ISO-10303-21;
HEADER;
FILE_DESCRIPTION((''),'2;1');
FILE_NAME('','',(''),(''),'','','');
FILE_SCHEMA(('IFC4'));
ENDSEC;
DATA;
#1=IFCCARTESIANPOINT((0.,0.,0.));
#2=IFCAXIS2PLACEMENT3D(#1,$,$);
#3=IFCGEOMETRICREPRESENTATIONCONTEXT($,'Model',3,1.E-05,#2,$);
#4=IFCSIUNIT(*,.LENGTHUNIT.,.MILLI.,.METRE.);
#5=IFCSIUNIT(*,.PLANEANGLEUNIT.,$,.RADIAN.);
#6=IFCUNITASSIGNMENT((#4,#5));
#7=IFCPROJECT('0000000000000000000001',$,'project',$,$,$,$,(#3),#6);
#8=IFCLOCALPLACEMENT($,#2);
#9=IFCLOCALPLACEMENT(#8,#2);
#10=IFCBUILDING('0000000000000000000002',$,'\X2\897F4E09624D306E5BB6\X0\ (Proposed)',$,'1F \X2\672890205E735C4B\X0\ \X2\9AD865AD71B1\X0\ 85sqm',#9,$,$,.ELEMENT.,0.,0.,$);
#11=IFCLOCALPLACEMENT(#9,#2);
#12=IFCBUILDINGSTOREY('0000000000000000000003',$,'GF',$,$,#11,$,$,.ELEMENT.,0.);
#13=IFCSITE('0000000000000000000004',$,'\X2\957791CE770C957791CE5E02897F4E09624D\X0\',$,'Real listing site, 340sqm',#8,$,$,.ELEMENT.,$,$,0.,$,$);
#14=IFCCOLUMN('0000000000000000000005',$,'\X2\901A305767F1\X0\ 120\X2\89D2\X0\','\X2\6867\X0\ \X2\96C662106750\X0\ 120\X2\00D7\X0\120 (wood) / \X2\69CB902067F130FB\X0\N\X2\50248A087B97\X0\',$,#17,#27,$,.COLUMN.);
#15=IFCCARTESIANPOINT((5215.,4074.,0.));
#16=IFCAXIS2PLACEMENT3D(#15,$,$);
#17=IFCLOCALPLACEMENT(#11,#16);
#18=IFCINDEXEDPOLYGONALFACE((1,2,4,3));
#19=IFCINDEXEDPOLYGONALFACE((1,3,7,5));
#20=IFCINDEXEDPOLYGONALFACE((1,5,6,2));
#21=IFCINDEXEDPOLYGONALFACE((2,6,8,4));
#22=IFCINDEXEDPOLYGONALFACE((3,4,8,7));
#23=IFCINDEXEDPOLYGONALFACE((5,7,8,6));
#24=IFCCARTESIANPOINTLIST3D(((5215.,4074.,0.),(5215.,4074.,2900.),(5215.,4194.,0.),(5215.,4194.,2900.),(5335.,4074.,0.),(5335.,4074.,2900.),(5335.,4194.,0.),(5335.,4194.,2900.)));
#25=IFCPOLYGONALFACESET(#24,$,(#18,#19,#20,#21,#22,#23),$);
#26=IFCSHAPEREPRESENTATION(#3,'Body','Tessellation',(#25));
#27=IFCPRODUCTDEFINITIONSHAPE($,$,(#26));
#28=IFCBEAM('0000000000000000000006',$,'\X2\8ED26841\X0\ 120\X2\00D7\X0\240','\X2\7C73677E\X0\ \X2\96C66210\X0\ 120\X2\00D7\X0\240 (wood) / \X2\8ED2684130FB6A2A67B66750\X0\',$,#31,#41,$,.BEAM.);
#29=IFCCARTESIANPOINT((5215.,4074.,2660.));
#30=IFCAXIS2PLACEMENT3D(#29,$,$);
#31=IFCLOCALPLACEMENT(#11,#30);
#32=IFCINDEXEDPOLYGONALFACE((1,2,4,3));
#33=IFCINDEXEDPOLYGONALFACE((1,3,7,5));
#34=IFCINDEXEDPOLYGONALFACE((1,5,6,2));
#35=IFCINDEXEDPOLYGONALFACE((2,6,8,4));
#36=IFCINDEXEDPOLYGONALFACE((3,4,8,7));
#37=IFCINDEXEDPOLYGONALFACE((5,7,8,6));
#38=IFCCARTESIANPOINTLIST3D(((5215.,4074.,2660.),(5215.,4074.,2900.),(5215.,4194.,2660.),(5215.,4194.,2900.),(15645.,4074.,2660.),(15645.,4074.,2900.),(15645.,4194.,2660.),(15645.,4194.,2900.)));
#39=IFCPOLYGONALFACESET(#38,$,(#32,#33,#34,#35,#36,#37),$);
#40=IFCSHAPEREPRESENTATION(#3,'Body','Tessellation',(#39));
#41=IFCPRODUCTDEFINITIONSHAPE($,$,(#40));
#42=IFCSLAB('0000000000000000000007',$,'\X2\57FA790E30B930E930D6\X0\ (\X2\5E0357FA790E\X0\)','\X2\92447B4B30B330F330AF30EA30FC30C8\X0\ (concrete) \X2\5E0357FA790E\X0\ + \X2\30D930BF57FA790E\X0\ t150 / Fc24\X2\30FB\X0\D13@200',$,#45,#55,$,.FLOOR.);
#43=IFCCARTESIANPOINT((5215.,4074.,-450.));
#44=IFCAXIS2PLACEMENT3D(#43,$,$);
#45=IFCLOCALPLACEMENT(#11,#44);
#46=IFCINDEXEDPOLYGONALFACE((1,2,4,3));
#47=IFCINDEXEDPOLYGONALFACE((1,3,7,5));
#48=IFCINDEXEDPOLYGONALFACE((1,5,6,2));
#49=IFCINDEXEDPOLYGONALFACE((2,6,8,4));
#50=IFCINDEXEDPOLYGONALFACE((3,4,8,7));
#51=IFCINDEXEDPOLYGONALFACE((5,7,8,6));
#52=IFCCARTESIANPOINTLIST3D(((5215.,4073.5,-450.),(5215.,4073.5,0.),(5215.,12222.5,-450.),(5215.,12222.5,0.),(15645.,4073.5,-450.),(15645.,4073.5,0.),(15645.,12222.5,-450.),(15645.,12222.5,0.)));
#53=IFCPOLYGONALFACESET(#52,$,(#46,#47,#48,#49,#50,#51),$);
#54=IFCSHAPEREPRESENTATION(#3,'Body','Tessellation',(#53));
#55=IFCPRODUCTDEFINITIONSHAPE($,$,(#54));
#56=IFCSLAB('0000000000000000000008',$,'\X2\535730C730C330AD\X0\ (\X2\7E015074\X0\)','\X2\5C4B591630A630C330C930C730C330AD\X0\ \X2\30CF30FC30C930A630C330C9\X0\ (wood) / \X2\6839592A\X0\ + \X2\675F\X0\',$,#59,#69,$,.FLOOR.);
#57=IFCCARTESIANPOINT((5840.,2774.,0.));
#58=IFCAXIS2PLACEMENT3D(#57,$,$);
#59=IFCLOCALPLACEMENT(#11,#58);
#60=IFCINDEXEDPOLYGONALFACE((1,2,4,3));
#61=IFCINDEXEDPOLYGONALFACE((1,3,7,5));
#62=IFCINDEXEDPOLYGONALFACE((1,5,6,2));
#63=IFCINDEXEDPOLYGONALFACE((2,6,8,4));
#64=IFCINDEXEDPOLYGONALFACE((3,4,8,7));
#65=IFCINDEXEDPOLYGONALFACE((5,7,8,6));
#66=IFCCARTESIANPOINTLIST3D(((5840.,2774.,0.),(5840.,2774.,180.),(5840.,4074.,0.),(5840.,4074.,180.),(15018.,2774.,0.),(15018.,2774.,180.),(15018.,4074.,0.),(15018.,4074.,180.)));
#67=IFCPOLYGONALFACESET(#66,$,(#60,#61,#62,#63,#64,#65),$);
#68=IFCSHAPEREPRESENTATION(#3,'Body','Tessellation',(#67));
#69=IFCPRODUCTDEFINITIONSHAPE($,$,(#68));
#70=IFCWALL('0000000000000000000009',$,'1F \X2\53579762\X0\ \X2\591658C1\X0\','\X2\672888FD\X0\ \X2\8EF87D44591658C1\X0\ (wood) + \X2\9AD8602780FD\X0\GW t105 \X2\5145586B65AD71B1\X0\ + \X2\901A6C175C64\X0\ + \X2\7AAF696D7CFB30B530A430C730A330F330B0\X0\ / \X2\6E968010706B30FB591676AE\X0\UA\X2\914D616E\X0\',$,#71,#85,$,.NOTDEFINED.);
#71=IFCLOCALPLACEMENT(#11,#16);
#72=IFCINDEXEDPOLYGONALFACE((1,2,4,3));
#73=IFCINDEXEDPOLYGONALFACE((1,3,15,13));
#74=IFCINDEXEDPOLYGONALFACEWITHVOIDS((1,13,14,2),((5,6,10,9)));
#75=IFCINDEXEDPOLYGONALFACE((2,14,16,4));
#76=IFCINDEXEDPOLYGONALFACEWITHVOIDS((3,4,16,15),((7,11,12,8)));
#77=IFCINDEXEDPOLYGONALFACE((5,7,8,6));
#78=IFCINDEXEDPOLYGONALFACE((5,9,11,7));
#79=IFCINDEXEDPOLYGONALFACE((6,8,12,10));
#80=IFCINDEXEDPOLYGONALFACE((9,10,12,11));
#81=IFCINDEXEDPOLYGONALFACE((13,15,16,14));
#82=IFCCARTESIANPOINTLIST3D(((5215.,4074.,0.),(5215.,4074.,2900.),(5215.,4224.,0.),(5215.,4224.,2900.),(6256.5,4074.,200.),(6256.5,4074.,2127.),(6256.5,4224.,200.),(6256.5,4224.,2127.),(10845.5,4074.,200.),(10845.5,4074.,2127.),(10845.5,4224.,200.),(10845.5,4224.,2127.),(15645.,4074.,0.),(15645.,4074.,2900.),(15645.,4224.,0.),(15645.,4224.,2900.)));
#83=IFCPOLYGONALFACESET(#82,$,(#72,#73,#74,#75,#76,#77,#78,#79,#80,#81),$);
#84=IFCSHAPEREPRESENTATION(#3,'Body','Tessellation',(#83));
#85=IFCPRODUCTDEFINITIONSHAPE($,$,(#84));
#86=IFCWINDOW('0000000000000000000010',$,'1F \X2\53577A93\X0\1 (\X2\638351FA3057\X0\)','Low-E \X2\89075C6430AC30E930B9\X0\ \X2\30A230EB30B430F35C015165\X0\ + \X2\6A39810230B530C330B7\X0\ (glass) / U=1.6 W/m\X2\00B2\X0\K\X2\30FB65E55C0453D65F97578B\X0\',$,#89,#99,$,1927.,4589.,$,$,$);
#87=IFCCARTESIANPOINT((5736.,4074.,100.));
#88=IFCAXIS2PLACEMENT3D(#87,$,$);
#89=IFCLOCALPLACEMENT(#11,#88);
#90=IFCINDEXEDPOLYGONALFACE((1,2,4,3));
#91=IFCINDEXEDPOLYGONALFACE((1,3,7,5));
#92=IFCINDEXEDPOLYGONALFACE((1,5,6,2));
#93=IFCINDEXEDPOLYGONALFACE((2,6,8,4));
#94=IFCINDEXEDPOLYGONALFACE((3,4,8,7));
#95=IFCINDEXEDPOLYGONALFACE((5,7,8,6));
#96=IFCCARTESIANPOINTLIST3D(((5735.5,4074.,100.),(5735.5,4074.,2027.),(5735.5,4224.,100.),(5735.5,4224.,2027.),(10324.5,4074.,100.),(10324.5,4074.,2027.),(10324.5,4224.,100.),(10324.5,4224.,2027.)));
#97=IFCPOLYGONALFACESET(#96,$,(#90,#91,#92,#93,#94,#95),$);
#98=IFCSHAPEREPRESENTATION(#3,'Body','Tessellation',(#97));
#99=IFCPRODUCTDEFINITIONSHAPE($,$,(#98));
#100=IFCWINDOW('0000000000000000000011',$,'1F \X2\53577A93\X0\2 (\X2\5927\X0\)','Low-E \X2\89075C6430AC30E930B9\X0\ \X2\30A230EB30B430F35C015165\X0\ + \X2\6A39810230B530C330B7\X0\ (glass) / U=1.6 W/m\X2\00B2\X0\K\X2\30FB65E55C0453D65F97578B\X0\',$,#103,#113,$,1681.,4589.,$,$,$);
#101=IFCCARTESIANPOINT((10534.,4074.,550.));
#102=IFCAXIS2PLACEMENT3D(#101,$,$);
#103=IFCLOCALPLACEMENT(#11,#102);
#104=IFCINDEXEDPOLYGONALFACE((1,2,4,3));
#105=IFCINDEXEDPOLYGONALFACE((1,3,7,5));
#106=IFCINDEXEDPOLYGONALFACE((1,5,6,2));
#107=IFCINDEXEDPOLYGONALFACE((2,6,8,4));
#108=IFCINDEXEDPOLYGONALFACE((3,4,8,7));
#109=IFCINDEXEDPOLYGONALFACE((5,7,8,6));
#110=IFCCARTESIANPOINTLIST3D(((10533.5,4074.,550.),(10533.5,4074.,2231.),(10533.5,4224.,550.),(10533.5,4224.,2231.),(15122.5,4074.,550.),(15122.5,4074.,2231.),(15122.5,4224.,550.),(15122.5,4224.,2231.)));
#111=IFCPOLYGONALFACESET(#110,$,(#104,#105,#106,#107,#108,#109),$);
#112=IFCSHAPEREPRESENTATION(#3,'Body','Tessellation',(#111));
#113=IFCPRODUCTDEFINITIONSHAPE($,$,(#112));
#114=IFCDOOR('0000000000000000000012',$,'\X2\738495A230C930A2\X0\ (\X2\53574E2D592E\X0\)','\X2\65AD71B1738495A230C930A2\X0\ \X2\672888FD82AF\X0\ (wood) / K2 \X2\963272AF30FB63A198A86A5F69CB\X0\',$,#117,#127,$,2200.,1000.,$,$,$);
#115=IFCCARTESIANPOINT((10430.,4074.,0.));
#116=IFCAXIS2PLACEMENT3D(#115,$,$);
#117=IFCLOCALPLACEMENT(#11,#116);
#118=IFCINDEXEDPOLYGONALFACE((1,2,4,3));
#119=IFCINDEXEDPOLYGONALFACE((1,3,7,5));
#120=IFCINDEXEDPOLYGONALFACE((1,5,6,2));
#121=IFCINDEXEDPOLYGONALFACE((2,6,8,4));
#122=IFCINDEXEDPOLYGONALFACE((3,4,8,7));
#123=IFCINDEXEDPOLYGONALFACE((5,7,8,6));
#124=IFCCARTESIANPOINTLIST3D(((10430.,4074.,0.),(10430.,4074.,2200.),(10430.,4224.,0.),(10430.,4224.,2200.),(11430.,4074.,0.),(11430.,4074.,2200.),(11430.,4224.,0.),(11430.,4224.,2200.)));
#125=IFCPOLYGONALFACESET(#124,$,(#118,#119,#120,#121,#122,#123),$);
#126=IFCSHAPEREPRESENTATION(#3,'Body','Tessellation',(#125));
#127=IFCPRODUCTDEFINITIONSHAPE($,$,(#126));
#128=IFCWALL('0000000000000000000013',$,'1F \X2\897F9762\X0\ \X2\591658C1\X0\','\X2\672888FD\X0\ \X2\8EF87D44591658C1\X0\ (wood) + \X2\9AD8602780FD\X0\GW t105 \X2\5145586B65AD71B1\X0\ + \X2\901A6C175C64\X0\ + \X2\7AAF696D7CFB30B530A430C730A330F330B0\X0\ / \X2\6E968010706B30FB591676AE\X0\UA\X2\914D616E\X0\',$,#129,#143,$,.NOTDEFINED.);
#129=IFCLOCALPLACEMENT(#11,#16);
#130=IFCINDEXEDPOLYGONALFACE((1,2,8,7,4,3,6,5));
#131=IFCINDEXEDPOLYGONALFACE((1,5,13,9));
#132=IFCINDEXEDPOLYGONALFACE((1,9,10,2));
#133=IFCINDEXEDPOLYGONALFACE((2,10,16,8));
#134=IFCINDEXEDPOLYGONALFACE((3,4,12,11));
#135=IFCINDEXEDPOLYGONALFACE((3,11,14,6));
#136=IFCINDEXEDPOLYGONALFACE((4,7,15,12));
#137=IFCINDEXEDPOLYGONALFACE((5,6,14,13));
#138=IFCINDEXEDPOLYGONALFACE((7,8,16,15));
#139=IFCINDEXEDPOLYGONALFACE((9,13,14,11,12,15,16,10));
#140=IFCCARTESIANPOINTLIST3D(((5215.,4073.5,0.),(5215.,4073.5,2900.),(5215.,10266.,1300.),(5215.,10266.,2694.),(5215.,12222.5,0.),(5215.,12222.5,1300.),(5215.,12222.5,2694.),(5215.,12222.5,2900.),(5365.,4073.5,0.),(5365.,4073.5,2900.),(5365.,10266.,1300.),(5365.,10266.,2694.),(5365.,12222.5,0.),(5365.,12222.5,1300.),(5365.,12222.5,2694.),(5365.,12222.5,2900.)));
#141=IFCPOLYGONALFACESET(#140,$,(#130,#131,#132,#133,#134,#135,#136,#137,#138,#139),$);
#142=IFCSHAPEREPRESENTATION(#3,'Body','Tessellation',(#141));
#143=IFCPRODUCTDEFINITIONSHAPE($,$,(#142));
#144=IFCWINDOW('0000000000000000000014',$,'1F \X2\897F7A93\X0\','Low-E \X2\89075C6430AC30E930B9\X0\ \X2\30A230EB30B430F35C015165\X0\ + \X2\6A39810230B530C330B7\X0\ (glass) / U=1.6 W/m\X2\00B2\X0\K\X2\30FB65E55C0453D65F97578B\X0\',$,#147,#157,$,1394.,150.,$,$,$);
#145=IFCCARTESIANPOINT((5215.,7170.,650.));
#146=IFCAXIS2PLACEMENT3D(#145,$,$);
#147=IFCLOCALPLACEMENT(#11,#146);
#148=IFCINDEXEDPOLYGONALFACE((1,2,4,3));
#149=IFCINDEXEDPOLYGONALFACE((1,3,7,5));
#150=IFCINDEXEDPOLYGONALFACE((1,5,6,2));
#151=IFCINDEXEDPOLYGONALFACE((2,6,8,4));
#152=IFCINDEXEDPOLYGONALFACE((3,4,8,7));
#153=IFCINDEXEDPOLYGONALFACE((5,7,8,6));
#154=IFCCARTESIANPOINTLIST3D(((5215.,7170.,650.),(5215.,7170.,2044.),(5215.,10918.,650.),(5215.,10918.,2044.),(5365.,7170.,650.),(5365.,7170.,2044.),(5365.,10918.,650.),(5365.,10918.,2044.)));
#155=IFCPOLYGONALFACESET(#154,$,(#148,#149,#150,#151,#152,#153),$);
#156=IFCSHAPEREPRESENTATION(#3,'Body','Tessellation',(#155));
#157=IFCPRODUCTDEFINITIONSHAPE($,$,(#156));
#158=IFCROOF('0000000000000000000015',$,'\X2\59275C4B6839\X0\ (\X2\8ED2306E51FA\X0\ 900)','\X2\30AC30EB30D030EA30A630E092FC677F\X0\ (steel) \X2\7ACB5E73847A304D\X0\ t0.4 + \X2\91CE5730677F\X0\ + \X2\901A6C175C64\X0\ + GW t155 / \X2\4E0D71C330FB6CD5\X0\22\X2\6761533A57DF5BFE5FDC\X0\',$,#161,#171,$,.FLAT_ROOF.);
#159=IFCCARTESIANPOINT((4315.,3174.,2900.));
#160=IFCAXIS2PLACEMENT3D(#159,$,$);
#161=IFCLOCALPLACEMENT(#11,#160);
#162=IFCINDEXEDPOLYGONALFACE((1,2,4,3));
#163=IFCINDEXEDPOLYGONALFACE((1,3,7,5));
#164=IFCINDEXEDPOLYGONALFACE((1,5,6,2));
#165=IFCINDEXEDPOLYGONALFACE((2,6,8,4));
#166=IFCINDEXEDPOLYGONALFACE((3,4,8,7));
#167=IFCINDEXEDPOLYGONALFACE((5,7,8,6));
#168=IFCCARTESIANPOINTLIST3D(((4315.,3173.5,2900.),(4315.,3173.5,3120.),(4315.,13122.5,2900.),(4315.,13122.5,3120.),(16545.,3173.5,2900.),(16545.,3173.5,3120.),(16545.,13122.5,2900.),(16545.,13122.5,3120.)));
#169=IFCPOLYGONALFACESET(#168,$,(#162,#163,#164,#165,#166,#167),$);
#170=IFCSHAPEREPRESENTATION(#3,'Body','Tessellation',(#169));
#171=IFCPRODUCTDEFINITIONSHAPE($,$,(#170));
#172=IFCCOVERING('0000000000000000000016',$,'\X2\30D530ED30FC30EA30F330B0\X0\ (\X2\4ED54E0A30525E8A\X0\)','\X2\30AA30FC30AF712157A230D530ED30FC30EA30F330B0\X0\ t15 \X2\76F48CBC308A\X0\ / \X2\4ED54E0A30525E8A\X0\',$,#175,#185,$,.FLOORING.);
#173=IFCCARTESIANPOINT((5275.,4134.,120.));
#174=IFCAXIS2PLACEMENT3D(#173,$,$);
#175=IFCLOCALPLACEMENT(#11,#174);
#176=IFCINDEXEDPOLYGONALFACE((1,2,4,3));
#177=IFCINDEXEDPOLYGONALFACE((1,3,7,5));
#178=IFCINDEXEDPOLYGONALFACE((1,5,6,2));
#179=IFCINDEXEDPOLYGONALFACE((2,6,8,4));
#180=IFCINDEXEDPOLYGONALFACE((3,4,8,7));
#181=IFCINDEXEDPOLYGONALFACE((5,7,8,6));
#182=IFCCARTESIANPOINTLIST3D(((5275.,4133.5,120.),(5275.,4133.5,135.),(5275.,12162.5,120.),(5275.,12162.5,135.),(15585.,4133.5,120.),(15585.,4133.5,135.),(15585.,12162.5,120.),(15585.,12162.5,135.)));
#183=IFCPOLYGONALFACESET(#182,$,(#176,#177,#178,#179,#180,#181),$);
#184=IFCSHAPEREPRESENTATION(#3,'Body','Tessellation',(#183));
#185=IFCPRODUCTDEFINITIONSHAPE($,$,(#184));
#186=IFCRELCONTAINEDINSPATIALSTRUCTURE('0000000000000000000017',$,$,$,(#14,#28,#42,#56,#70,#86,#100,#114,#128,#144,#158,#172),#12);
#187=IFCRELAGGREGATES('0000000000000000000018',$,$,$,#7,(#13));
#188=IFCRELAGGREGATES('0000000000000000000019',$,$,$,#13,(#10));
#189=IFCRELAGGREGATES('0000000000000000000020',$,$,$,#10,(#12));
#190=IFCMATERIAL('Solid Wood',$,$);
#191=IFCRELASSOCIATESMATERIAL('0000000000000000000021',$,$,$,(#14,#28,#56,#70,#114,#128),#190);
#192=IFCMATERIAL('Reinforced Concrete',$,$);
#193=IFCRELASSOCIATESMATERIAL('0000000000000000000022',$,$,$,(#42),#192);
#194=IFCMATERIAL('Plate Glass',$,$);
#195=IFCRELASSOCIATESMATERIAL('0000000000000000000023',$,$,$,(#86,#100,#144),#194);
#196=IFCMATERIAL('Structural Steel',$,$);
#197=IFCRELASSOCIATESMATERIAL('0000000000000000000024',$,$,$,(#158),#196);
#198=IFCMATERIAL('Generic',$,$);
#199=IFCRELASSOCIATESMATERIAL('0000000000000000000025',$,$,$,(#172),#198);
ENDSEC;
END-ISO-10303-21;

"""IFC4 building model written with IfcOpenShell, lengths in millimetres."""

from ifc_helpers import new_model, si_unit, frame, frame_2d, origin, place, context, project, spatial, rectangle, extrude, material, element, fill, save


model = new_model("IFC4")

# Units and contexts
model_context = context("Model", 3, precision=1e-05, world=origin())
ifc_project = project(units=[si_unit("LENGTHUNIT", "METRE", prefix="MILLI"), si_unit("PLANEANGLEUNIT", "RADIAN")], contexts=[model_context])

# Site, building, storey
site_placement = place(None, origin())
site = spatial("IfcSite", under=ifc_project, at=site_placement, Name="長野県長野市西三才", ObjectType="Real listing site, 340sqm", CompositionType="ELEMENT", RefElevation=0.0)
building_placement = place(site_placement, origin())
building = spatial("IfcBuilding", under=site, at=building_placement, Name="西三才の家 (Proposed)", ObjectType="1F 木造平屋 高断熱 85sqm", CompositionType="ELEMENT", ElevationOfRefHeight=0.0, ElevationOfTerrain=0.0)
storey_placement = place(building_placement, origin())
storey = spatial("IfcBuildingStorey", under=building, at=storey_placement, Name="GF", CompositionType="ELEMENT", Elevation=0.0)

# Column
ifc_material_1 = material(Name="Solid Wood")
column_1_placement = place(storey_placement, frame((5215.0, 4074.0, 0.0)))
element("IfcColumn", 1, at=column_1_placement, inside=storey, material=ifc_material_1, Name="通し柱 120角", Description="桧 集成材 120×120 (wood) / 構造柱・N値計算", PredefinedType="COLUMN", context=model_context, shape_type="SweptSolid", body=[
    extrude(rectangle(XDim=120.0, YDim=120.0, at=frame_2d((60.0, 60.0))), frame((5215.0, 4074.0, 0.0)), (0.0, 0.0, 1.0), 2900.0),
])

# Beam
beam_1_placement = place(storey_placement, frame((5215.0, 4074.0, 2660.0)))
element("IfcBeam", 2, at=beam_1_placement, inside=storey, material=ifc_material_1, Name="軒桁 120×240", Description="米松 集成 120×240 (wood) / 軒桁・横架材", PredefinedType="BEAM", context=model_context, shape_type="SweptSolid", body=[
    extrude(rectangle(XDim=10430.0, YDim=120.0, at=frame_2d((5215.0, 60.0))), frame((5215.0, 4074.0, 2660.0)), (0.0, 0.0, 1.0), 240.0),
])

# Slabs
ifc_material_2 = material(Name="Reinforced Concrete")
slab_1_placement = place(storey_placement, frame((5215.0, 4074.0, -450.0)))
element("IfcSlab", 3, at=slab_1_placement, inside=storey, material=ifc_material_2, Name="基礎スラブ (布基礎)", Description="鉄筋コンクリート (concrete) 布基礎 + ベタ基礎 t150 / Fc24・D13@200", PredefinedType="FLOOR", context=model_context, shape_type="SweptSolid", body=[
    extrude(rectangle(XDim=10430.0, YDim=8149.0, at=frame_2d((5215.0, 4074.0))), frame((5215.0, 4074.0, -450.0)), (0.0, 0.0, 1.0), 450.0),
])
slab_2_placement = place(storey_placement, frame((5840.0, 2774.0, 0.0)))
element("IfcSlab", 4, at=slab_2_placement, inside=storey, material=ifc_material_1, Name="南デッキ (縁側)", Description="屋外ウッドデッキ ハードウッド (wood) / 根太 + 束", PredefinedType="FLOOR", context=model_context, shape_type="SweptSolid", body=[
    extrude(rectangle(XDim=9178.0, YDim=1300.0, at=frame_2d((4589.0, 650.0))), frame((5840.0, 2774.0, 0.0)), (0.0, 0.0, 1.0), 180.0),
])

# Wall, openings, windows, door
wall_1_placement = place(storey_placement, frame((5215.0, 4074.0, 0.0)))
wall_1 = element("IfcWall", 5, at=wall_1_placement, inside=storey, material=ifc_material_1, Name="1F 南面 外壁", Description="木製 軸組外壁 (wood) + 高性能GW t105 充填断熱 + 通気層 + 窯業系サイディング / 準耐火・外皮UA配慮", PredefinedType="NOTDEFINED", context=model_context, shape_type="SweptSolid", body=[
    extrude(rectangle(XDim=10430.0, YDim=150.0, at=frame_2d((5215.0, 75.0))), frame((5215.0, 4074.0, 0.0)), (0.0, 0.0, 1.0), 2900.0),
])
opening_1_placement = place(storey_placement, frame((5736.0, 4074.0, 100.0)))
opening_1 = element("IfcOpeningElement", 6, at=opening_1_placement, cuts=wall_1, PredefinedType="NOTDEFINED", context=model_context, shape_type="SweptSolid", body=[
    extrude(rectangle(XDim=4589.0, YDim=150.0, at=frame_2d((2294.0, 75.0))), frame((5736.0, 4074.0, 100.0)), (0.0, 0.0, 1.0), 1927.0),
])
opening_2_placement = place(storey_placement, frame((10534.0, 4074.0, 550.0)))
opening_2 = element("IfcOpeningElement", 7, at=opening_2_placement, cuts=wall_1, PredefinedType="NOTDEFINED", context=model_context, shape_type="SweptSolid", body=[
    extrude(rectangle(XDim=4589.0, YDim=150.0, at=frame_2d((2294.0, 75.0))), frame((10534.0, 4074.0, 550.0)), (0.0, 0.0, 1.0), 1681.0),
])
opening_3_placement = place(storey_placement, frame((10430.0, 4074.0, 0.0)))
opening_3 = element("IfcOpeningElement", 8, at=opening_3_placement, cuts=wall_1, PredefinedType="NOTDEFINED", context=model_context, shape_type="SweptSolid", body=[
    extrude(rectangle(XDim=1000.0, YDim=150.0, at=frame_2d((500.0, 75.0))), frame((10430.0, 4074.0, 0.0)), (0.0, 0.0, 1.0), 2200.0),
])
ifc_material_3 = material(Name="Plate Glass")
window_1_placement = place(storey_placement, frame((5736.0, 4074.0, 100.0)))
window_1 = element("IfcWindow", 9, at=window_1_placement, inside=storey, material=ifc_material_3, Name="1F 南窓1 (掃出し)", Description="Low-E 複層ガラス アルゴン封入 + 樹脂サッシ (glass) / U=1.6 W/m²K・日射取得型", OverallHeight=1927.0, OverallWidth=4589.0, context=model_context, shape_type="SweptSolid", body=[
    extrude(rectangle(XDim=4589.0, YDim=150.0, at=frame_2d((2294.0, 75.0))), frame((5736.0, 4074.0, 100.0)), (0.0, 0.0, 1.0), 1927.0),
])
fill(opening_1, window_1)
window_2_placement = place(storey_placement, frame((10534.0, 4074.0, 550.0)))
window_2 = element("IfcWindow", 10, at=window_2_placement, inside=storey, material=ifc_material_3, Name="1F 南窓2 (大)", Description="Low-E 複層ガラス アルゴン封入 + 樹脂サッシ (glass) / U=1.6 W/m²K・日射取得型", OverallHeight=1681.0, OverallWidth=4589.0, context=model_context, shape_type="SweptSolid", body=[
    extrude(rectangle(XDim=4589.0, YDim=150.0, at=frame_2d((2294.0, 75.0))), frame((10534.0, 4074.0, 550.0)), (0.0, 0.0, 1.0), 1681.0),
])
fill(opening_2, window_2)
door_placement = place(storey_placement, frame((10430.0, 4074.0, 0.0)))
door = element("IfcDoor", 11, at=door_placement, inside=storey, material=ifc_material_1, Name="玄関ドア (南中央)", Description="断熱玄関ドア 木製芯 (wood) / K2 防犯・採風機構", OverallHeight=2200.0, OverallWidth=1000.0, context=model_context, shape_type="SweptSolid", body=[
    extrude(rectangle(XDim=1000.0, YDim=150.0, at=frame_2d((500.0, 75.0))), frame((10430.0, 4074.0, 0.0)), (0.0, 0.0, 1.0), 2200.0),
])
fill(opening_3, door)

# Wall, opening, window
wall_2_placement = place(storey_placement, frame((5215.0, 4074.0, 0.0)))
wall_2 = element("IfcWall", 12, at=wall_2_placement, inside=storey, material=ifc_material_1, Name="1F 西面 外壁", Description="木製 軸組外壁 (wood) + 高性能GW t105 充填断熱 + 通気層 + 窯業系サイディング / 準耐火・外皮UA配慮", PredefinedType="NOTDEFINED", context=model_context, shape_type="SweptSolid", body=[
    extrude(rectangle(XDim=150.0, YDim=8149.0, at=frame_2d((75.0, 4074.0))), frame((5215.0, 4074.0, 0.0)), (0.0, 0.0, 1.0), 2900.0),
])
opening_4_placement = place(storey_placement, frame((5215.0, 7170.0, 650.0)))
opening_4 = element("IfcOpeningElement", 13, at=opening_4_placement, cuts=wall_2, PredefinedType="NOTDEFINED", context=model_context, shape_type="SweptSolid", body=[
    extrude(rectangle(XDim=150.0, YDim=3748.0, at=frame_2d((75.0, 1874.0))), frame((5215.0, 7170.0, 650.0)), (0.0, 0.0, 1.0), 1394.0),
])
window_3_placement = place(storey_placement, frame((5215.0, 7170.0, 650.0)))
window_3 = element("IfcWindow", 14, at=window_3_placement, inside=storey, material=ifc_material_3, Name="1F 西窓", Description="Low-E 複層ガラス アルゴン封入 + 樹脂サッシ (glass) / U=1.6 W/m²K・日射取得型", OverallHeight=1394.0, OverallWidth=150.0, context=model_context, shape_type="SweptSolid", body=[
    extrude(rectangle(XDim=150.0, YDim=3748.0, at=frame_2d((75.0, 1874.0))), frame((5215.0, 7170.0, 650.0)), (0.0, 0.0, 1.0), 1394.0),
])
fill(opening_4, window_3)

# Roof
ifc_material_4 = material(Name="Structural Steel")
roof_placement = place(storey_placement, frame((4315.0, 3174.0, 2900.0)))
element("IfcRoof", 15, at=roof_placement, inside=storey, material=ifc_material_4, Name="大屋根 (軒の出 900)", Description="ガルバリウム鋼板 (steel) 立平葺き t0.4 + 野地板 + 通気層 + GW t155 / 不燃・法22条区域対応", PredefinedType="FLAT_ROOF", context=model_context, shape_type="SweptSolid", body=[
    extrude(rectangle(XDim=12230.0, YDim=9949.0, at=frame_2d((6115.0, 4974.0))), frame((4315.0, 3174.0, 2900.0)), (0.0, 0.0, 1.0), 220.0),
])

# Covering
ifc_material_5 = material(Name="Generic")
covering_1_placement = place(storey_placement, frame((5275.0, 4134.0, 120.0)))
element("IfcCovering", 16, at=covering_1_placement, inside=storey, material=ifc_material_5, Name="フローリング (仕上げ床)", Description="オーク無垢フローリング t15 直貼り / 仕上げ床", PredefinedType="FLOORING", context=model_context, shape_type="SweptSolid", body=[
    extrude(rectangle(XDim=10310.0, YDim=8029.0, at=frame_2d((5155.0, 4014.0))), frame((5275.0, 4134.0, 120.0)), (0.0, 0.0, 1.0), 15.0),
])

save(model, "model.ifc")
